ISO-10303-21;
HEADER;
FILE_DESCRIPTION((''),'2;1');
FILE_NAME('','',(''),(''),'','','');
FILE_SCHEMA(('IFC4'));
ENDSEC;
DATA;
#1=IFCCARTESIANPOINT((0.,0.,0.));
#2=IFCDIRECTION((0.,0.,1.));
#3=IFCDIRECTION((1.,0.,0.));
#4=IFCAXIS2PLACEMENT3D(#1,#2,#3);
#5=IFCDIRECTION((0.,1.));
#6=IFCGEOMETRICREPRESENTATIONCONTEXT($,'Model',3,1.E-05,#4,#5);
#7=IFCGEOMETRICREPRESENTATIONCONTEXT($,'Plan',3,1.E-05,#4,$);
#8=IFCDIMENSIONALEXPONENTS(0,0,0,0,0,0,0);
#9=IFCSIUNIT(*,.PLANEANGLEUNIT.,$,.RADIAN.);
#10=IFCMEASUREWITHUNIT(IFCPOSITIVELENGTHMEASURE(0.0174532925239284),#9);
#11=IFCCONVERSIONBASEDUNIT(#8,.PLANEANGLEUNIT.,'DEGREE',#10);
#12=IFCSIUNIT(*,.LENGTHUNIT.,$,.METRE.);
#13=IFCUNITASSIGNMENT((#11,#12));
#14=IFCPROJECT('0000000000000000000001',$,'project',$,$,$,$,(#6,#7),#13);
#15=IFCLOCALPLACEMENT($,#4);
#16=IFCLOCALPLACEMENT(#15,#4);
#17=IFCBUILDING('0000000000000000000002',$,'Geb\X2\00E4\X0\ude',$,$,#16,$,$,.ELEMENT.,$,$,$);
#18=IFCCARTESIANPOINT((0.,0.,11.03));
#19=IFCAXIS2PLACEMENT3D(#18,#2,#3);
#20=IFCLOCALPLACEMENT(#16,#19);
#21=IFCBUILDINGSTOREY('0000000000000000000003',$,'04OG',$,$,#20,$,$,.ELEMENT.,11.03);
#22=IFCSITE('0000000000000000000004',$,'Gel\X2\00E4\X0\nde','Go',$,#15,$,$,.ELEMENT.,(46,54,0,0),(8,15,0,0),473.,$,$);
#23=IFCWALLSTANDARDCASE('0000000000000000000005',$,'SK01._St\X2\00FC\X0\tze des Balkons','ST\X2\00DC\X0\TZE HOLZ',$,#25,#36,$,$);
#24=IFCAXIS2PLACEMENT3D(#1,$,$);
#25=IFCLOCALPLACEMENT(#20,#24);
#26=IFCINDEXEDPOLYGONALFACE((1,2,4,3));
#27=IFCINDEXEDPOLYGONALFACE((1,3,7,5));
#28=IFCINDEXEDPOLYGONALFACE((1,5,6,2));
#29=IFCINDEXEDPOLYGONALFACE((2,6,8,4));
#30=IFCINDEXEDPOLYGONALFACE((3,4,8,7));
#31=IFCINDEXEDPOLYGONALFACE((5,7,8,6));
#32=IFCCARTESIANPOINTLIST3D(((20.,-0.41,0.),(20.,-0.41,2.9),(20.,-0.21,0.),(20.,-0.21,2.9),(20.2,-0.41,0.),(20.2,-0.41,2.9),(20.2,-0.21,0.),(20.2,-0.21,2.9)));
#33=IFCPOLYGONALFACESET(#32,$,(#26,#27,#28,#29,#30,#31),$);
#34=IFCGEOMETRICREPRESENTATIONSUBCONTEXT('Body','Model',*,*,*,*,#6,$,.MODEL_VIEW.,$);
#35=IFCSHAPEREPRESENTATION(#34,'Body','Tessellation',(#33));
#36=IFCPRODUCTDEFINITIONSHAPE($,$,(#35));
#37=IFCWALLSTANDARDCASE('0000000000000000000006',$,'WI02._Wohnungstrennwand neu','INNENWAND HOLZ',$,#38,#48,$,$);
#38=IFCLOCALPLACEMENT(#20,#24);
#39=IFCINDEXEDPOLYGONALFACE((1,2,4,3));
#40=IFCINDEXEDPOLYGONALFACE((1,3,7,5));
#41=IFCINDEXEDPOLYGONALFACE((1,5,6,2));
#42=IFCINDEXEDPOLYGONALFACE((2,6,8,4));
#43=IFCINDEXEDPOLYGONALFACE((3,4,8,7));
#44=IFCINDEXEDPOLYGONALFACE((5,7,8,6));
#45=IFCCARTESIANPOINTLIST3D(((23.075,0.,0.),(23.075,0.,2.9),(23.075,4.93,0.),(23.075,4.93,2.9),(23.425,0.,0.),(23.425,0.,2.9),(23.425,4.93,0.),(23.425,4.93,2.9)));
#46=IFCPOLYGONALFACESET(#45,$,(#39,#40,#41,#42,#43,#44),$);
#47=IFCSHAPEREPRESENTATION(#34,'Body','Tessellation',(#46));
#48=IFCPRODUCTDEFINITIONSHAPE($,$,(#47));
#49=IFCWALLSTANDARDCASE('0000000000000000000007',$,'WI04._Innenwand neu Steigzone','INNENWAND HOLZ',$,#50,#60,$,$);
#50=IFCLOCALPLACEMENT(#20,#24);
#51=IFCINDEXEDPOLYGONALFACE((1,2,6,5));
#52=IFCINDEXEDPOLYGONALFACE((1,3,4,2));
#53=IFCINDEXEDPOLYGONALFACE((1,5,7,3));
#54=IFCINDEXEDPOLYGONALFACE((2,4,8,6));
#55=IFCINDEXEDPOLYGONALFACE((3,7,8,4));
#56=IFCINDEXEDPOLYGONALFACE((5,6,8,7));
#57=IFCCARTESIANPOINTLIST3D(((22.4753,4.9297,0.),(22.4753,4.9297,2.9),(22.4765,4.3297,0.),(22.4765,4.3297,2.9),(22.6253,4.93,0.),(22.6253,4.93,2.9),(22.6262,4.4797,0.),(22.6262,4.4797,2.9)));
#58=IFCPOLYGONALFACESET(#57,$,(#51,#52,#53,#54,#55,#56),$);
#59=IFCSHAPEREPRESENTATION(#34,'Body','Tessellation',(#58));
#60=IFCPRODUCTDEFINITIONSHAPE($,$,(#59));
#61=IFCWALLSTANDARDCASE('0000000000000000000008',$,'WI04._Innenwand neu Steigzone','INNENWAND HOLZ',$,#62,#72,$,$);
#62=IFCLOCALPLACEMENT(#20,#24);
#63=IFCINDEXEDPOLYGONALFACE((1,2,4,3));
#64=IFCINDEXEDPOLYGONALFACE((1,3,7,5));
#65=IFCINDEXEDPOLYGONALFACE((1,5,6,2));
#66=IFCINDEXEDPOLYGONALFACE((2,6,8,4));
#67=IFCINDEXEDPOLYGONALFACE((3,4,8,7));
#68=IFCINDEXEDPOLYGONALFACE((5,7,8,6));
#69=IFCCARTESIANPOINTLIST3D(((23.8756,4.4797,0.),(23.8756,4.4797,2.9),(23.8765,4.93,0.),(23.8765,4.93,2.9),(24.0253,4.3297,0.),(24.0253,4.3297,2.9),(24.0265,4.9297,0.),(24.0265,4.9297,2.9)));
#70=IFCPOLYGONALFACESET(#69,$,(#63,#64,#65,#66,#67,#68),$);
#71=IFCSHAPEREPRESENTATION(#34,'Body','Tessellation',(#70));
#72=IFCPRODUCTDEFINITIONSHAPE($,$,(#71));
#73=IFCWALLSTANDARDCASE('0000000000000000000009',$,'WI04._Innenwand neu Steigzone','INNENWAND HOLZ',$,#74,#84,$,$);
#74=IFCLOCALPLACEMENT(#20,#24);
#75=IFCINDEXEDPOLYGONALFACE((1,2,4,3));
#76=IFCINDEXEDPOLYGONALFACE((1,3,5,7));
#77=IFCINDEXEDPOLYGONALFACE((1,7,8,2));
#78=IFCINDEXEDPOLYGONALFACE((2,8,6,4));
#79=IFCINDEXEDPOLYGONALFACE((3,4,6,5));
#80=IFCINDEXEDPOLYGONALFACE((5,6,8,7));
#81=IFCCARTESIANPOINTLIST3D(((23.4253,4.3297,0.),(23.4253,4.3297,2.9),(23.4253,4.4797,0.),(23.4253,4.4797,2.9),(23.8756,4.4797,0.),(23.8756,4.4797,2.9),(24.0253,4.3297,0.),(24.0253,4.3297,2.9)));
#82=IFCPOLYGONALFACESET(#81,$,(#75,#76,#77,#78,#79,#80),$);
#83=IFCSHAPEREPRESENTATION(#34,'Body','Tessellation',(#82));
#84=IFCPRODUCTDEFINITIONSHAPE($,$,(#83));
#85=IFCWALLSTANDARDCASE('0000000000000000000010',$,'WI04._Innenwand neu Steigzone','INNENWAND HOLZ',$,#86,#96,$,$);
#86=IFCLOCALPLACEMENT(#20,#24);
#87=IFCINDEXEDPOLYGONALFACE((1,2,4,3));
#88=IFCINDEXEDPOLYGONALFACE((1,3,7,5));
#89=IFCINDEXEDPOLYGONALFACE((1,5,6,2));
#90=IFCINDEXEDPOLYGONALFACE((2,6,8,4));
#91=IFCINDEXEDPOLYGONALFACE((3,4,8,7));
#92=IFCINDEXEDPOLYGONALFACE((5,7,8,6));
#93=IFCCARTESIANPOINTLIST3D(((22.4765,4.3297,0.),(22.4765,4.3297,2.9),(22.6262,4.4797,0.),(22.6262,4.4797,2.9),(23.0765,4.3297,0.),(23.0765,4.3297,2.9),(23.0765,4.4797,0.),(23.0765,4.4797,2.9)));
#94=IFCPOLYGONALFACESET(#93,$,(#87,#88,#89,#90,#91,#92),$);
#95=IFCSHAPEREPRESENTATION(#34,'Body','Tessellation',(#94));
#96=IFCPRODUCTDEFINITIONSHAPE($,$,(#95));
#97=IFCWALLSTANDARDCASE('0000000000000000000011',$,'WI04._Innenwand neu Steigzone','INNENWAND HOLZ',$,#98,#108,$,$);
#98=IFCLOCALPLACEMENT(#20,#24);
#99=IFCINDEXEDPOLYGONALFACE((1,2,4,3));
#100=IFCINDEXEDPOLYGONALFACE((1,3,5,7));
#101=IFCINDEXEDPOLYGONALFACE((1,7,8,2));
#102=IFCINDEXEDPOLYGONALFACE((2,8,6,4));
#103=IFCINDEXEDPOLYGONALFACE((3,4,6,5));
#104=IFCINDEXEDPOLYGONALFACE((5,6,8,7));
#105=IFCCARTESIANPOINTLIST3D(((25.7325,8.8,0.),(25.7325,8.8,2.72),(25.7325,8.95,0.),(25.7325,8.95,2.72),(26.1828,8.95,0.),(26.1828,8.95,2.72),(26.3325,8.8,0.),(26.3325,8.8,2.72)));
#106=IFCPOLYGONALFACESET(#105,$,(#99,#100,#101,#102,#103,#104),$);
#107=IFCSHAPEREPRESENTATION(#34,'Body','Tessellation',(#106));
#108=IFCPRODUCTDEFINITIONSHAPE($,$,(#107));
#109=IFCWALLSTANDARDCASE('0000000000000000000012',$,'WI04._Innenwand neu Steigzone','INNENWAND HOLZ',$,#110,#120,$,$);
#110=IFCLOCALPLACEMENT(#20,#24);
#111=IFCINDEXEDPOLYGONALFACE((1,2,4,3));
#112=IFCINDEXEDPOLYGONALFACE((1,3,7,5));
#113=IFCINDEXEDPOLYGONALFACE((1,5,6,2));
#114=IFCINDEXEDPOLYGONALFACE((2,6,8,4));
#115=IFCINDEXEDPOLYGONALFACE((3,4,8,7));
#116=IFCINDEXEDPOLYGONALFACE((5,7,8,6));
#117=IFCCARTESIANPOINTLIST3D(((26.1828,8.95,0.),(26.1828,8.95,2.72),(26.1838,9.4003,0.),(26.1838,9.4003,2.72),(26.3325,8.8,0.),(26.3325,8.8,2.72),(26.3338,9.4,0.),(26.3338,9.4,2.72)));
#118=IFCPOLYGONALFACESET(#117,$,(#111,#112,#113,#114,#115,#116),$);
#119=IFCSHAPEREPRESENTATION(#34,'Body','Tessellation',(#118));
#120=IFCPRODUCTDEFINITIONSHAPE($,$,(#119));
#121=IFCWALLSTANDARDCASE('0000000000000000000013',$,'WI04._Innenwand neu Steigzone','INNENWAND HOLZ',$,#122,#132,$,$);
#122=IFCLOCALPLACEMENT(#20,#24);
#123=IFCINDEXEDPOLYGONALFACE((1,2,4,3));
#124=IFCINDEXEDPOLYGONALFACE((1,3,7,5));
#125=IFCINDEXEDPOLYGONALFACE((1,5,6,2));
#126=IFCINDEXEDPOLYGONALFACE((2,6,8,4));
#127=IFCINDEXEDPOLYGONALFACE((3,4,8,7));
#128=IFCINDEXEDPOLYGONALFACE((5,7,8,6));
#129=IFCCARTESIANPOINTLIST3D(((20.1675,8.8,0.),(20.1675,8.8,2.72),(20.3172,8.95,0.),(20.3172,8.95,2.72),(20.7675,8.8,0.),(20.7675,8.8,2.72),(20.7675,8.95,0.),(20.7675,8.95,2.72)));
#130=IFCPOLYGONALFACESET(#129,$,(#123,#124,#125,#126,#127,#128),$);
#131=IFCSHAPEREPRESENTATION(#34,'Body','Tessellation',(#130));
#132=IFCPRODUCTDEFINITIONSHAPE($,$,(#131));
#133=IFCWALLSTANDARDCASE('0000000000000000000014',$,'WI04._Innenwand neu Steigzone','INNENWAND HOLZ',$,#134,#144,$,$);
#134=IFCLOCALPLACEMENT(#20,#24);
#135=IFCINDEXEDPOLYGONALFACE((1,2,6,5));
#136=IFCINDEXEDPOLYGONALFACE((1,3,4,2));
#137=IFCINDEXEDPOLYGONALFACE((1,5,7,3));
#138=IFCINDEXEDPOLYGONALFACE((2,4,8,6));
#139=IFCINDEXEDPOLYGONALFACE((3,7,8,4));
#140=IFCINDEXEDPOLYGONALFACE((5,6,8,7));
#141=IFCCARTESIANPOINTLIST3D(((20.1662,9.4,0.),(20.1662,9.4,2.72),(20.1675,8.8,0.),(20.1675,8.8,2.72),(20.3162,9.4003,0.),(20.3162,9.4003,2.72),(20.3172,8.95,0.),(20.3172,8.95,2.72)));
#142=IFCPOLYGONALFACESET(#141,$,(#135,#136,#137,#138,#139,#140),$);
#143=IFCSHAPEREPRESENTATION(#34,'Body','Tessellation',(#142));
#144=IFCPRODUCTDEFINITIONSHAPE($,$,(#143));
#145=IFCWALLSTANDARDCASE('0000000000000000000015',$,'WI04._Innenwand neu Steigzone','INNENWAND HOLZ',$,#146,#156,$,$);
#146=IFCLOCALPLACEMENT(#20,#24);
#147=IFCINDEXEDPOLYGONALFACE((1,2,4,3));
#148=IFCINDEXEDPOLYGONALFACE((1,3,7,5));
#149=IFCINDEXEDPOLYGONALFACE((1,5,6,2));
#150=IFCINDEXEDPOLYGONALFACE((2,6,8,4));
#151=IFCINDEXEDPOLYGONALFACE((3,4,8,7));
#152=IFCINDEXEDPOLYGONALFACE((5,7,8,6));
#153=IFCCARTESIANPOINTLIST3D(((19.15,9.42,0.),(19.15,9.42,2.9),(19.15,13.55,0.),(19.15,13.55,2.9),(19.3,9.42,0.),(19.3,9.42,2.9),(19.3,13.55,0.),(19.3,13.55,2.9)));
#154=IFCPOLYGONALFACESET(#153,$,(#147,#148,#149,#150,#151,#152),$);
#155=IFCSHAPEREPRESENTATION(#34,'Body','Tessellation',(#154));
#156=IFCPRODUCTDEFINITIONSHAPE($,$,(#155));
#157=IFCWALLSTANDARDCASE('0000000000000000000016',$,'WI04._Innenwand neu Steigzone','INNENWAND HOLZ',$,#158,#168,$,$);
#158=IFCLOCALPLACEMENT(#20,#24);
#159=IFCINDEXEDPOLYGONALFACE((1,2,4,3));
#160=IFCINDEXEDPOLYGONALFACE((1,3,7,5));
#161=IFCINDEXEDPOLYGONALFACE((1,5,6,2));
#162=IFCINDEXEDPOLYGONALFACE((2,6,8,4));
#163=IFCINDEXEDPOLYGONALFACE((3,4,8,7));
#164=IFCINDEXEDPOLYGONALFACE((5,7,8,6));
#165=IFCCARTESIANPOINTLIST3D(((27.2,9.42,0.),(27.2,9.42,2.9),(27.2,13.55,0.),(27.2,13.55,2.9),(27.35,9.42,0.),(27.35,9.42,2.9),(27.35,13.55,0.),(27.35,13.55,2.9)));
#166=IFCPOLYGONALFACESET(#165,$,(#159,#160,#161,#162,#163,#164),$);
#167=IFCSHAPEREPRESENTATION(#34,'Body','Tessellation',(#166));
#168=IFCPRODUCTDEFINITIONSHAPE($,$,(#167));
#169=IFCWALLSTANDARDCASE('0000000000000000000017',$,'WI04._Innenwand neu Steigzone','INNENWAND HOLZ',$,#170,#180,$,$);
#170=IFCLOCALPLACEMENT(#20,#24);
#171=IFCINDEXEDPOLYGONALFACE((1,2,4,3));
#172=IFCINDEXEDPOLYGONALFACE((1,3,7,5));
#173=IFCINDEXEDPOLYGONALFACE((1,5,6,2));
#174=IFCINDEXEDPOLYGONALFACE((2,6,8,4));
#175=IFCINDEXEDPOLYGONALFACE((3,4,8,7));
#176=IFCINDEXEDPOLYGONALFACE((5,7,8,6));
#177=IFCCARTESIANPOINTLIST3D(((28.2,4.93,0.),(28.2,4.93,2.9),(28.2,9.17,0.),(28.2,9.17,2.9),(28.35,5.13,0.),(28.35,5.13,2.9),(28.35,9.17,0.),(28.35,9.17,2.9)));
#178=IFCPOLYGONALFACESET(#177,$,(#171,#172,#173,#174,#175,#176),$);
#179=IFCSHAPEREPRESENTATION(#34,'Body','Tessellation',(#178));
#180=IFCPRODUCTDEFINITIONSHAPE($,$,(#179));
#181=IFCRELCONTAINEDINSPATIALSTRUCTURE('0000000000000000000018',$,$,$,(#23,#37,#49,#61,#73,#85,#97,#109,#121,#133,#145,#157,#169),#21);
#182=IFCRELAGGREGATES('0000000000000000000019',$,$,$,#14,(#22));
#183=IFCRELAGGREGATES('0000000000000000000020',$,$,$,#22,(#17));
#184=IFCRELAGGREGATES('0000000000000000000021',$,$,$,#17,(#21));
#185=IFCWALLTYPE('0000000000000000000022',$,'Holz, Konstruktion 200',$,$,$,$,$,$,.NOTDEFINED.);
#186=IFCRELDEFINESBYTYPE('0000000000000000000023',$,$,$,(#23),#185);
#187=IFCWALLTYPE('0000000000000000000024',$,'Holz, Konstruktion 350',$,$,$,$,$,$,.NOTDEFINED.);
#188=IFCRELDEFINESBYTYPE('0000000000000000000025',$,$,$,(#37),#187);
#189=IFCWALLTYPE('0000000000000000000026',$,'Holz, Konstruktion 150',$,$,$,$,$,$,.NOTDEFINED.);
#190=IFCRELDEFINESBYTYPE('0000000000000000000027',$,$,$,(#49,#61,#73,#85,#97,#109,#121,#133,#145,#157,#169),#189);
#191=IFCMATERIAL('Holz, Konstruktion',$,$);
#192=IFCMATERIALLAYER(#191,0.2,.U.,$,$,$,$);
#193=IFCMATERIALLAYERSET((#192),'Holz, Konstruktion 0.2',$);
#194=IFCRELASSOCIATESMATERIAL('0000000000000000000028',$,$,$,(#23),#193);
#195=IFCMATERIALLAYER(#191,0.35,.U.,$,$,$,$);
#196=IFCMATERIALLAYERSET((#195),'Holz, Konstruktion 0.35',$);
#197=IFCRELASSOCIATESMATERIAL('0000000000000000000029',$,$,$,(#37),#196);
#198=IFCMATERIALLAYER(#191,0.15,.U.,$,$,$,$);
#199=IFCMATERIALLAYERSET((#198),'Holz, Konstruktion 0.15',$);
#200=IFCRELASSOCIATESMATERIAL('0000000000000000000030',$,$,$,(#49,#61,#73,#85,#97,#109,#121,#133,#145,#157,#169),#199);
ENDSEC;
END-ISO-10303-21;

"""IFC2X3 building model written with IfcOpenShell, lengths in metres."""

from ifc_helpers import new_model, entity, si_unit, converted_unit, direction, frame, origin_with_axes, place, context, subcontext, project, spatial, polyline, outline, extrude, material, layer, layer_set, layer_usage, type_object, element, save


model = new_model("IFC2X3")

# Units and contexts
model_context = context("Model", 3, precision=1e-05, world=origin_with_axes(), true_north=direction((0.0, 1.0)))
plan_context = context("Plan", 3, precision=1e-05, world=origin_with_axes())
body_context = subcontext(model_context, "Body", "Model", "MODEL_VIEW")
ifc_project = project(units=[converted_unit("PLANEANGLEUNIT", "DEGREE", entity("IfcPositiveLengthMeasure", 0.0174532925239284), si_unit("PLANEANGLEUNIT", "RADIAN"), dimensions=[0, 0, 0, 0, 0, 0, 0]), si_unit("LENGTHUNIT", "METRE")], contexts=[model_context, plan_context])

# Site, building, storey
site_placement = place(None, origin_with_axes())
site = spatial("IfcSite", under=ifc_project, at=site_placement, Name="Gelände", Description="Go", CompositionType="ELEMENT", RefLatitude=(46, 54, 0, 0), RefLongitude=(8, 15, 0, 0), RefElevation=473.0)
building_placement = place(site_placement, origin_with_axes())
building = spatial("IfcBuilding", under=site, at=building_placement, Name="Gebäude", CompositionType="ELEMENT")
storey_placement = place(building_placement, frame((0.0, 0.0, 11.03), z_axis=(0.0, 0.0, 1.0), x_axis=(1.0, 0.0, 0.0)))
storey = spatial("IfcBuildingStorey", under=building, at=storey_placement, Name="04OG", CompositionType="ELEMENT", Elevation=11.03)

# Shared definitions
ifc_material_1 = material(Name="Holz, Konstruktion")

# Walls
ifc_layer_1 = layer(ifc_material_1, 0.2, ventilated="UNKNOWN")
ifc_layer_set_1 = layer_set([ifc_layer_1], Name="Holz, Konstruktion 0.2")
wall_type_1 = type_object("IfcWallType", Name="Holz, Konstruktion 200", PredefinedType="NOTDEFINED")
ifc_layer_usage_1 = layer_usage(ifc_layer_set_1, "AXIS2", "POSITIVE", 0.0)
wall_1_placement = place(storey_placement, frame((20.2, -0.41, 0.0), z_axis=(0.0, 0.0, 1.0), x_axis=(0.0, 1.0, 0.0)))
element("IfcWallStandardCase", 1, at=wall_1_placement, inside=storey, type_object=wall_type_1, material=ifc_layer_usage_1, Name="SK01._Stütze des Balkons", Description="STÜTZE HOLZ", context=body_context, shape_type="SweptSolid", body=[
    extrude(outline(polyline([(0.0, 0.0), (0.2, 0.0), (0.2, 0.2), (0.0, 0.2), (0.0, 0.0)])), origin_with_axes(), (0.0, 0.0, 1.0), 2.9),
])
ifc_layer_2 = layer(ifc_material_1, 0.35, ventilated="UNKNOWN")
ifc_layer_set_2 = layer_set([ifc_layer_2], Name="Holz, Konstruktion 0.35")
ifc_layer_usage_2 = layer_usage(ifc_layer_set_2, "AXIS2", "NEGATIVE", 0.0)
wall_type_2 = type_object("IfcWallType", Name="Holz, Konstruktion 350", PredefinedType="NOTDEFINED")
wall_2_placement = place(storey_placement, frame((23.425, 4.93, 0.0), z_axis=(0.0, 0.0, 1.0), x_axis=(0.0, -1.0, 0.0)))
element("IfcWallStandardCase", 2, at=wall_2_placement, inside=storey, type_object=wall_type_2, material=ifc_layer_usage_2, Name="WI02._Wohnungstrennwand neu", Description="INNENWAND HOLZ", context=body_context, shape_type="SweptSolid", body=[
    extrude(outline(polyline([(0.0, -0.35), (4.93, -0.35), (4.93, 0.0), (0.0, 0.0), (0.0, -0.35)])), origin_with_axes(), (0.0, 0.0, 1.0), 2.9),
])
ifc_layer_3 = layer(ifc_material_1, 0.15, ventilated="UNKNOWN")
ifc_layer_set_3 = layer_set([ifc_layer_3], Name="Holz, Konstruktion 0.15")
ifc_layer_usage_3 = layer_usage(ifc_layer_set_3, "AXIS2", "NEGATIVE", 0.0)
wall_type_3 = type_object("IfcWallType", Name="Holz, Konstruktion 150", PredefinedType="NOTDEFINED")
wall_3_placement = place(storey_placement, frame((22.4765, 4.3297, 0.0), z_axis=(0.0, 0.0, 1.0), x_axis=(-0.002118, 0.999998, 0.0)))
element("IfcWallStandardCase", 3, at=wall_3_placement, inside=storey, type_object=wall_type_3, material=ifc_layer_usage_3, Name="WI04._Innenwand neu Steigzone", Description="INNENWAND HOLZ", context=body_context, shape_type="SweptSolid", body=[
    extrude(outline(polyline([(0.1497, -0.15), (0.6, -0.15), (0.6, 0.0), (0.0, 0.0), (0.1497, -0.15)])), origin_with_axes(), (0.0, 0.0, 1.0), 2.9),
])
ifc_layer_usage_4 = layer_usage(ifc_layer_set_3, "AXIS2", "NEGATIVE", 0.0)
wall_4_placement = place(storey_placement, frame((24.0265, 4.9297, 0.0), z_axis=(0.0, 0.0, 1.0), x_axis=(-0.002118, -0.999998, 0.0)))
element("IfcWallStandardCase", 4, at=wall_4_placement, inside=storey, type_object=wall_type_3, material=ifc_layer_usage_4, Name="WI04._Innenwand neu Steigzone", Description="INNENWAND HOLZ", context=body_context, shape_type="SweptSolid", body=[
    extrude(outline(polyline([(0.0, -0.15), (0.4503, -0.15), (0.6, 0.0), (0.0, 0.0), (0.0, -0.15)])), origin_with_axes(), (0.0, 0.0, 1.0), 2.9),
])
ifc_layer_usage_5 = layer_usage(ifc_layer_set_3, "AXIS2", "NEGATIVE", 0.0)
wall_5_placement = place(storey_placement, frame((24.0253, 4.3297, 0.0), z_axis=(0.0, 0.0, 1.0), x_axis=(-1.0, 0.0, 0.0)))
element("IfcWallStandardCase", 5, at=wall_5_placement, inside=storey, type_object=wall_type_3, material=ifc_layer_usage_5, Name="WI04._Innenwand neu Steigzone", Description="INNENWAND HOLZ", context=body_context, shape_type="SweptSolid", body=[
    extrude(outline(polyline([(0.1497, -0.15), (0.6, -0.15), (0.6, 0.0), (0.0, 0.0), (0.1497, -0.15)])), origin_with_axes(), (0.0, 0.0, 1.0), 2.9),
])
ifc_layer_usage_6 = layer_usage(ifc_layer_set_3, "AXIS2", "NEGATIVE", 0.0)
wall_6_placement = place(storey_placement, frame((23.0765, 4.3297, 0.0), z_axis=(0.0, 0.0, 1.0), x_axis=(-1.0, 0.0, 0.0)))
element("IfcWallStandardCase", 6, at=wall_6_placement, inside=storey, type_object=wall_type_3, material=ifc_layer_usage_6, Name="WI04._Innenwand neu Steigzone", Description="INNENWAND HOLZ", context=body_context, shape_type="SweptSolid", body=[
    extrude(outline(polyline([(0.0, -0.15), (0.4503, -0.15), (0.6, 0.0), (0.0, 0.0), (0.0, -0.15)])), origin_with_axes(), (0.0, 0.0, 1.0), 2.9),
])
ifc_layer_usage_7 = layer_usage(ifc_layer_set_3, "AXIS2", "NEGATIVE", 0.0)
wall_7_placement = place(storey_placement, frame((26.3325, 8.8, 0.0), z_axis=(0.0, 0.0, 1.0), x_axis=(-1.0, 0.0, 0.0)))
element("IfcWallStandardCase", 7, at=wall_7_placement, inside=storey, type_object=wall_type_3, material=ifc_layer_usage_7, Name="WI04._Innenwand neu Steigzone", Description="INNENWAND HOLZ", context=body_context, shape_type="SweptSolid", body=[
    extrude(outline(polyline([(0.1497, -0.15), (0.6, -0.15), (0.6, 0.0), (0.0, 0.0), (0.1497, -0.15)])), origin_with_axes(), (0.0, 0.0, 1.0), 2.72),
])
ifc_layer_usage_8 = layer_usage(ifc_layer_set_3, "AXIS2", "NEGATIVE", 0.0)
wall_8_placement = place(storey_placement, frame((26.3338, 9.4, 0.0), z_axis=(0.0, 0.0, 1.0), x_axis=(-0.002118, -0.999998, 0.0)))
element("IfcWallStandardCase", 8, at=wall_8_placement, inside=storey, type_object=wall_type_3, material=ifc_layer_usage_8, Name="WI04._Innenwand neu Steigzone", Description="INNENWAND HOLZ", context=body_context, shape_type="SweptSolid", body=[
    extrude(outline(polyline([(0.0, -0.15), (0.4503, -0.15), (0.6, 0.0), (0.0, 0.0), (0.0, -0.15)])), origin_with_axes(), (0.0, 0.0, 1.0), 2.72),
])
ifc_layer_usage_9 = layer_usage(ifc_layer_set_3, "AXIS2", "POSITIVE", 0.0)
wall_9_placement = place(storey_placement, frame((20.1675, 8.8, 0.0), z_axis=(0.0, 0.0, 1.0), x_axis=(1.0, 0.0, 0.0)))
element("IfcWallStandardCase", 9, at=wall_9_placement, inside=storey, type_object=wall_type_3, material=ifc_layer_usage_9, Name="WI04._Innenwand neu Steigzone", Description="INNENWAND HOLZ", context=body_context, shape_type="SweptSolid", body=[
    extrude(outline(polyline([(0.0, 0.0), (0.6, 0.0), (0.6, 0.15), (0.1497, 0.15), (0.0, 0.0)])), origin_with_axes(), (0.0, 0.0, 1.0), 2.72),
])
ifc_layer_usage_10 = layer_usage(ifc_layer_set_3, "AXIS2", "POSITIVE", 0.0)
wall_10_placement = place(storey_placement, frame((20.1662, 9.4, 0.0), z_axis=(0.0, 0.0, 1.0), x_axis=(0.002118, -0.999998, 0.0)))
element("IfcWallStandardCase", 10, at=wall_10_placement, inside=storey, type_object=wall_type_3, material=ifc_layer_usage_10, Name="WI04._Innenwand neu Steigzone", Description="INNENWAND HOLZ", context=body_context, shape_type="SweptSolid", body=[
    extrude(outline(polyline([(0.0, 0.0), (0.6, 0.0), (0.4503, 0.15), (0.0, 0.15), (0.0, 0.0)])), origin_with_axes(), (0.0, 0.0, 1.0), 2.72),
])
ifc_layer_usage_11 = layer_usage(ifc_layer_set_3, "AXIS2", "POSITIVE", 0.0)
wall_11_placement = place(storey_placement, frame((19.15, 13.55, 0.0), z_axis=(0.0, 0.0, 1.0), x_axis=(0.0, -1.0, 0.0)))
element("IfcWallStandardCase", 11, at=wall_11_placement, inside=storey, type_object=wall_type_3, material=ifc_layer_usage_11, Name="WI04._Innenwand neu Steigzone", Description="INNENWAND HOLZ", context=body_context, shape_type="SweptSolid", body=[
    extrude(outline(polyline([(0.0, 0.0), (4.13, 0.0), (4.13, 0.15), (0.0, 0.15), (0.0, 0.0)])), origin_with_axes(), (0.0, 0.0, 1.0), 2.9),
])
ifc_layer_usage_12 = layer_usage(ifc_layer_set_3, "AXIS2", "POSITIVE", 0.0)
wall_12_placement = place(storey_placement, frame((27.2, 13.55, 0.0), z_axis=(0.0, 0.0, 1.0), x_axis=(0.0, -1.0, 0.0)))
element("IfcWallStandardCase", 12, at=wall_12_placement, inside=storey, type_object=wall_type_3, material=ifc_layer_usage_12, Name="WI04._Innenwand neu Steigzone", Description="INNENWAND HOLZ", context=body_context, shape_type="SweptSolid", body=[
    extrude(outline(polyline([(0.0, 0.0), (4.13, 0.0), (4.13, 0.15), (0.0, 0.15), (0.0, 0.0)])), origin_with_axes(), (0.0, 0.0, 1.0), 2.9),
])
ifc_layer_usage_13 = layer_usage(ifc_layer_set_3, "AXIS2", "POSITIVE", 0.0)
wall_13_placement = place(storey_placement, frame((28.2, 9.17, 0.0), z_axis=(0.0, 0.0, 1.0), x_axis=(0.0, -1.0, 0.0)))
element("IfcWallStandardCase", 13, at=wall_13_placement, inside=storey, type_object=wall_type_3, material=ifc_layer_usage_13, Name="WI04._Innenwand neu Steigzone", Description="INNENWAND HOLZ", context=body_context, shape_type="SweptSolid", body=[
    extrude(outline(polyline([(0.0, 0.0), (4.24, 0.0), (4.04, 0.15), (0.0, 0.15), (0.0, 0.0)])), origin_with_axes(), (0.0, 0.0, 1.0), 2.9),
])

save(model, "model.ifc")
